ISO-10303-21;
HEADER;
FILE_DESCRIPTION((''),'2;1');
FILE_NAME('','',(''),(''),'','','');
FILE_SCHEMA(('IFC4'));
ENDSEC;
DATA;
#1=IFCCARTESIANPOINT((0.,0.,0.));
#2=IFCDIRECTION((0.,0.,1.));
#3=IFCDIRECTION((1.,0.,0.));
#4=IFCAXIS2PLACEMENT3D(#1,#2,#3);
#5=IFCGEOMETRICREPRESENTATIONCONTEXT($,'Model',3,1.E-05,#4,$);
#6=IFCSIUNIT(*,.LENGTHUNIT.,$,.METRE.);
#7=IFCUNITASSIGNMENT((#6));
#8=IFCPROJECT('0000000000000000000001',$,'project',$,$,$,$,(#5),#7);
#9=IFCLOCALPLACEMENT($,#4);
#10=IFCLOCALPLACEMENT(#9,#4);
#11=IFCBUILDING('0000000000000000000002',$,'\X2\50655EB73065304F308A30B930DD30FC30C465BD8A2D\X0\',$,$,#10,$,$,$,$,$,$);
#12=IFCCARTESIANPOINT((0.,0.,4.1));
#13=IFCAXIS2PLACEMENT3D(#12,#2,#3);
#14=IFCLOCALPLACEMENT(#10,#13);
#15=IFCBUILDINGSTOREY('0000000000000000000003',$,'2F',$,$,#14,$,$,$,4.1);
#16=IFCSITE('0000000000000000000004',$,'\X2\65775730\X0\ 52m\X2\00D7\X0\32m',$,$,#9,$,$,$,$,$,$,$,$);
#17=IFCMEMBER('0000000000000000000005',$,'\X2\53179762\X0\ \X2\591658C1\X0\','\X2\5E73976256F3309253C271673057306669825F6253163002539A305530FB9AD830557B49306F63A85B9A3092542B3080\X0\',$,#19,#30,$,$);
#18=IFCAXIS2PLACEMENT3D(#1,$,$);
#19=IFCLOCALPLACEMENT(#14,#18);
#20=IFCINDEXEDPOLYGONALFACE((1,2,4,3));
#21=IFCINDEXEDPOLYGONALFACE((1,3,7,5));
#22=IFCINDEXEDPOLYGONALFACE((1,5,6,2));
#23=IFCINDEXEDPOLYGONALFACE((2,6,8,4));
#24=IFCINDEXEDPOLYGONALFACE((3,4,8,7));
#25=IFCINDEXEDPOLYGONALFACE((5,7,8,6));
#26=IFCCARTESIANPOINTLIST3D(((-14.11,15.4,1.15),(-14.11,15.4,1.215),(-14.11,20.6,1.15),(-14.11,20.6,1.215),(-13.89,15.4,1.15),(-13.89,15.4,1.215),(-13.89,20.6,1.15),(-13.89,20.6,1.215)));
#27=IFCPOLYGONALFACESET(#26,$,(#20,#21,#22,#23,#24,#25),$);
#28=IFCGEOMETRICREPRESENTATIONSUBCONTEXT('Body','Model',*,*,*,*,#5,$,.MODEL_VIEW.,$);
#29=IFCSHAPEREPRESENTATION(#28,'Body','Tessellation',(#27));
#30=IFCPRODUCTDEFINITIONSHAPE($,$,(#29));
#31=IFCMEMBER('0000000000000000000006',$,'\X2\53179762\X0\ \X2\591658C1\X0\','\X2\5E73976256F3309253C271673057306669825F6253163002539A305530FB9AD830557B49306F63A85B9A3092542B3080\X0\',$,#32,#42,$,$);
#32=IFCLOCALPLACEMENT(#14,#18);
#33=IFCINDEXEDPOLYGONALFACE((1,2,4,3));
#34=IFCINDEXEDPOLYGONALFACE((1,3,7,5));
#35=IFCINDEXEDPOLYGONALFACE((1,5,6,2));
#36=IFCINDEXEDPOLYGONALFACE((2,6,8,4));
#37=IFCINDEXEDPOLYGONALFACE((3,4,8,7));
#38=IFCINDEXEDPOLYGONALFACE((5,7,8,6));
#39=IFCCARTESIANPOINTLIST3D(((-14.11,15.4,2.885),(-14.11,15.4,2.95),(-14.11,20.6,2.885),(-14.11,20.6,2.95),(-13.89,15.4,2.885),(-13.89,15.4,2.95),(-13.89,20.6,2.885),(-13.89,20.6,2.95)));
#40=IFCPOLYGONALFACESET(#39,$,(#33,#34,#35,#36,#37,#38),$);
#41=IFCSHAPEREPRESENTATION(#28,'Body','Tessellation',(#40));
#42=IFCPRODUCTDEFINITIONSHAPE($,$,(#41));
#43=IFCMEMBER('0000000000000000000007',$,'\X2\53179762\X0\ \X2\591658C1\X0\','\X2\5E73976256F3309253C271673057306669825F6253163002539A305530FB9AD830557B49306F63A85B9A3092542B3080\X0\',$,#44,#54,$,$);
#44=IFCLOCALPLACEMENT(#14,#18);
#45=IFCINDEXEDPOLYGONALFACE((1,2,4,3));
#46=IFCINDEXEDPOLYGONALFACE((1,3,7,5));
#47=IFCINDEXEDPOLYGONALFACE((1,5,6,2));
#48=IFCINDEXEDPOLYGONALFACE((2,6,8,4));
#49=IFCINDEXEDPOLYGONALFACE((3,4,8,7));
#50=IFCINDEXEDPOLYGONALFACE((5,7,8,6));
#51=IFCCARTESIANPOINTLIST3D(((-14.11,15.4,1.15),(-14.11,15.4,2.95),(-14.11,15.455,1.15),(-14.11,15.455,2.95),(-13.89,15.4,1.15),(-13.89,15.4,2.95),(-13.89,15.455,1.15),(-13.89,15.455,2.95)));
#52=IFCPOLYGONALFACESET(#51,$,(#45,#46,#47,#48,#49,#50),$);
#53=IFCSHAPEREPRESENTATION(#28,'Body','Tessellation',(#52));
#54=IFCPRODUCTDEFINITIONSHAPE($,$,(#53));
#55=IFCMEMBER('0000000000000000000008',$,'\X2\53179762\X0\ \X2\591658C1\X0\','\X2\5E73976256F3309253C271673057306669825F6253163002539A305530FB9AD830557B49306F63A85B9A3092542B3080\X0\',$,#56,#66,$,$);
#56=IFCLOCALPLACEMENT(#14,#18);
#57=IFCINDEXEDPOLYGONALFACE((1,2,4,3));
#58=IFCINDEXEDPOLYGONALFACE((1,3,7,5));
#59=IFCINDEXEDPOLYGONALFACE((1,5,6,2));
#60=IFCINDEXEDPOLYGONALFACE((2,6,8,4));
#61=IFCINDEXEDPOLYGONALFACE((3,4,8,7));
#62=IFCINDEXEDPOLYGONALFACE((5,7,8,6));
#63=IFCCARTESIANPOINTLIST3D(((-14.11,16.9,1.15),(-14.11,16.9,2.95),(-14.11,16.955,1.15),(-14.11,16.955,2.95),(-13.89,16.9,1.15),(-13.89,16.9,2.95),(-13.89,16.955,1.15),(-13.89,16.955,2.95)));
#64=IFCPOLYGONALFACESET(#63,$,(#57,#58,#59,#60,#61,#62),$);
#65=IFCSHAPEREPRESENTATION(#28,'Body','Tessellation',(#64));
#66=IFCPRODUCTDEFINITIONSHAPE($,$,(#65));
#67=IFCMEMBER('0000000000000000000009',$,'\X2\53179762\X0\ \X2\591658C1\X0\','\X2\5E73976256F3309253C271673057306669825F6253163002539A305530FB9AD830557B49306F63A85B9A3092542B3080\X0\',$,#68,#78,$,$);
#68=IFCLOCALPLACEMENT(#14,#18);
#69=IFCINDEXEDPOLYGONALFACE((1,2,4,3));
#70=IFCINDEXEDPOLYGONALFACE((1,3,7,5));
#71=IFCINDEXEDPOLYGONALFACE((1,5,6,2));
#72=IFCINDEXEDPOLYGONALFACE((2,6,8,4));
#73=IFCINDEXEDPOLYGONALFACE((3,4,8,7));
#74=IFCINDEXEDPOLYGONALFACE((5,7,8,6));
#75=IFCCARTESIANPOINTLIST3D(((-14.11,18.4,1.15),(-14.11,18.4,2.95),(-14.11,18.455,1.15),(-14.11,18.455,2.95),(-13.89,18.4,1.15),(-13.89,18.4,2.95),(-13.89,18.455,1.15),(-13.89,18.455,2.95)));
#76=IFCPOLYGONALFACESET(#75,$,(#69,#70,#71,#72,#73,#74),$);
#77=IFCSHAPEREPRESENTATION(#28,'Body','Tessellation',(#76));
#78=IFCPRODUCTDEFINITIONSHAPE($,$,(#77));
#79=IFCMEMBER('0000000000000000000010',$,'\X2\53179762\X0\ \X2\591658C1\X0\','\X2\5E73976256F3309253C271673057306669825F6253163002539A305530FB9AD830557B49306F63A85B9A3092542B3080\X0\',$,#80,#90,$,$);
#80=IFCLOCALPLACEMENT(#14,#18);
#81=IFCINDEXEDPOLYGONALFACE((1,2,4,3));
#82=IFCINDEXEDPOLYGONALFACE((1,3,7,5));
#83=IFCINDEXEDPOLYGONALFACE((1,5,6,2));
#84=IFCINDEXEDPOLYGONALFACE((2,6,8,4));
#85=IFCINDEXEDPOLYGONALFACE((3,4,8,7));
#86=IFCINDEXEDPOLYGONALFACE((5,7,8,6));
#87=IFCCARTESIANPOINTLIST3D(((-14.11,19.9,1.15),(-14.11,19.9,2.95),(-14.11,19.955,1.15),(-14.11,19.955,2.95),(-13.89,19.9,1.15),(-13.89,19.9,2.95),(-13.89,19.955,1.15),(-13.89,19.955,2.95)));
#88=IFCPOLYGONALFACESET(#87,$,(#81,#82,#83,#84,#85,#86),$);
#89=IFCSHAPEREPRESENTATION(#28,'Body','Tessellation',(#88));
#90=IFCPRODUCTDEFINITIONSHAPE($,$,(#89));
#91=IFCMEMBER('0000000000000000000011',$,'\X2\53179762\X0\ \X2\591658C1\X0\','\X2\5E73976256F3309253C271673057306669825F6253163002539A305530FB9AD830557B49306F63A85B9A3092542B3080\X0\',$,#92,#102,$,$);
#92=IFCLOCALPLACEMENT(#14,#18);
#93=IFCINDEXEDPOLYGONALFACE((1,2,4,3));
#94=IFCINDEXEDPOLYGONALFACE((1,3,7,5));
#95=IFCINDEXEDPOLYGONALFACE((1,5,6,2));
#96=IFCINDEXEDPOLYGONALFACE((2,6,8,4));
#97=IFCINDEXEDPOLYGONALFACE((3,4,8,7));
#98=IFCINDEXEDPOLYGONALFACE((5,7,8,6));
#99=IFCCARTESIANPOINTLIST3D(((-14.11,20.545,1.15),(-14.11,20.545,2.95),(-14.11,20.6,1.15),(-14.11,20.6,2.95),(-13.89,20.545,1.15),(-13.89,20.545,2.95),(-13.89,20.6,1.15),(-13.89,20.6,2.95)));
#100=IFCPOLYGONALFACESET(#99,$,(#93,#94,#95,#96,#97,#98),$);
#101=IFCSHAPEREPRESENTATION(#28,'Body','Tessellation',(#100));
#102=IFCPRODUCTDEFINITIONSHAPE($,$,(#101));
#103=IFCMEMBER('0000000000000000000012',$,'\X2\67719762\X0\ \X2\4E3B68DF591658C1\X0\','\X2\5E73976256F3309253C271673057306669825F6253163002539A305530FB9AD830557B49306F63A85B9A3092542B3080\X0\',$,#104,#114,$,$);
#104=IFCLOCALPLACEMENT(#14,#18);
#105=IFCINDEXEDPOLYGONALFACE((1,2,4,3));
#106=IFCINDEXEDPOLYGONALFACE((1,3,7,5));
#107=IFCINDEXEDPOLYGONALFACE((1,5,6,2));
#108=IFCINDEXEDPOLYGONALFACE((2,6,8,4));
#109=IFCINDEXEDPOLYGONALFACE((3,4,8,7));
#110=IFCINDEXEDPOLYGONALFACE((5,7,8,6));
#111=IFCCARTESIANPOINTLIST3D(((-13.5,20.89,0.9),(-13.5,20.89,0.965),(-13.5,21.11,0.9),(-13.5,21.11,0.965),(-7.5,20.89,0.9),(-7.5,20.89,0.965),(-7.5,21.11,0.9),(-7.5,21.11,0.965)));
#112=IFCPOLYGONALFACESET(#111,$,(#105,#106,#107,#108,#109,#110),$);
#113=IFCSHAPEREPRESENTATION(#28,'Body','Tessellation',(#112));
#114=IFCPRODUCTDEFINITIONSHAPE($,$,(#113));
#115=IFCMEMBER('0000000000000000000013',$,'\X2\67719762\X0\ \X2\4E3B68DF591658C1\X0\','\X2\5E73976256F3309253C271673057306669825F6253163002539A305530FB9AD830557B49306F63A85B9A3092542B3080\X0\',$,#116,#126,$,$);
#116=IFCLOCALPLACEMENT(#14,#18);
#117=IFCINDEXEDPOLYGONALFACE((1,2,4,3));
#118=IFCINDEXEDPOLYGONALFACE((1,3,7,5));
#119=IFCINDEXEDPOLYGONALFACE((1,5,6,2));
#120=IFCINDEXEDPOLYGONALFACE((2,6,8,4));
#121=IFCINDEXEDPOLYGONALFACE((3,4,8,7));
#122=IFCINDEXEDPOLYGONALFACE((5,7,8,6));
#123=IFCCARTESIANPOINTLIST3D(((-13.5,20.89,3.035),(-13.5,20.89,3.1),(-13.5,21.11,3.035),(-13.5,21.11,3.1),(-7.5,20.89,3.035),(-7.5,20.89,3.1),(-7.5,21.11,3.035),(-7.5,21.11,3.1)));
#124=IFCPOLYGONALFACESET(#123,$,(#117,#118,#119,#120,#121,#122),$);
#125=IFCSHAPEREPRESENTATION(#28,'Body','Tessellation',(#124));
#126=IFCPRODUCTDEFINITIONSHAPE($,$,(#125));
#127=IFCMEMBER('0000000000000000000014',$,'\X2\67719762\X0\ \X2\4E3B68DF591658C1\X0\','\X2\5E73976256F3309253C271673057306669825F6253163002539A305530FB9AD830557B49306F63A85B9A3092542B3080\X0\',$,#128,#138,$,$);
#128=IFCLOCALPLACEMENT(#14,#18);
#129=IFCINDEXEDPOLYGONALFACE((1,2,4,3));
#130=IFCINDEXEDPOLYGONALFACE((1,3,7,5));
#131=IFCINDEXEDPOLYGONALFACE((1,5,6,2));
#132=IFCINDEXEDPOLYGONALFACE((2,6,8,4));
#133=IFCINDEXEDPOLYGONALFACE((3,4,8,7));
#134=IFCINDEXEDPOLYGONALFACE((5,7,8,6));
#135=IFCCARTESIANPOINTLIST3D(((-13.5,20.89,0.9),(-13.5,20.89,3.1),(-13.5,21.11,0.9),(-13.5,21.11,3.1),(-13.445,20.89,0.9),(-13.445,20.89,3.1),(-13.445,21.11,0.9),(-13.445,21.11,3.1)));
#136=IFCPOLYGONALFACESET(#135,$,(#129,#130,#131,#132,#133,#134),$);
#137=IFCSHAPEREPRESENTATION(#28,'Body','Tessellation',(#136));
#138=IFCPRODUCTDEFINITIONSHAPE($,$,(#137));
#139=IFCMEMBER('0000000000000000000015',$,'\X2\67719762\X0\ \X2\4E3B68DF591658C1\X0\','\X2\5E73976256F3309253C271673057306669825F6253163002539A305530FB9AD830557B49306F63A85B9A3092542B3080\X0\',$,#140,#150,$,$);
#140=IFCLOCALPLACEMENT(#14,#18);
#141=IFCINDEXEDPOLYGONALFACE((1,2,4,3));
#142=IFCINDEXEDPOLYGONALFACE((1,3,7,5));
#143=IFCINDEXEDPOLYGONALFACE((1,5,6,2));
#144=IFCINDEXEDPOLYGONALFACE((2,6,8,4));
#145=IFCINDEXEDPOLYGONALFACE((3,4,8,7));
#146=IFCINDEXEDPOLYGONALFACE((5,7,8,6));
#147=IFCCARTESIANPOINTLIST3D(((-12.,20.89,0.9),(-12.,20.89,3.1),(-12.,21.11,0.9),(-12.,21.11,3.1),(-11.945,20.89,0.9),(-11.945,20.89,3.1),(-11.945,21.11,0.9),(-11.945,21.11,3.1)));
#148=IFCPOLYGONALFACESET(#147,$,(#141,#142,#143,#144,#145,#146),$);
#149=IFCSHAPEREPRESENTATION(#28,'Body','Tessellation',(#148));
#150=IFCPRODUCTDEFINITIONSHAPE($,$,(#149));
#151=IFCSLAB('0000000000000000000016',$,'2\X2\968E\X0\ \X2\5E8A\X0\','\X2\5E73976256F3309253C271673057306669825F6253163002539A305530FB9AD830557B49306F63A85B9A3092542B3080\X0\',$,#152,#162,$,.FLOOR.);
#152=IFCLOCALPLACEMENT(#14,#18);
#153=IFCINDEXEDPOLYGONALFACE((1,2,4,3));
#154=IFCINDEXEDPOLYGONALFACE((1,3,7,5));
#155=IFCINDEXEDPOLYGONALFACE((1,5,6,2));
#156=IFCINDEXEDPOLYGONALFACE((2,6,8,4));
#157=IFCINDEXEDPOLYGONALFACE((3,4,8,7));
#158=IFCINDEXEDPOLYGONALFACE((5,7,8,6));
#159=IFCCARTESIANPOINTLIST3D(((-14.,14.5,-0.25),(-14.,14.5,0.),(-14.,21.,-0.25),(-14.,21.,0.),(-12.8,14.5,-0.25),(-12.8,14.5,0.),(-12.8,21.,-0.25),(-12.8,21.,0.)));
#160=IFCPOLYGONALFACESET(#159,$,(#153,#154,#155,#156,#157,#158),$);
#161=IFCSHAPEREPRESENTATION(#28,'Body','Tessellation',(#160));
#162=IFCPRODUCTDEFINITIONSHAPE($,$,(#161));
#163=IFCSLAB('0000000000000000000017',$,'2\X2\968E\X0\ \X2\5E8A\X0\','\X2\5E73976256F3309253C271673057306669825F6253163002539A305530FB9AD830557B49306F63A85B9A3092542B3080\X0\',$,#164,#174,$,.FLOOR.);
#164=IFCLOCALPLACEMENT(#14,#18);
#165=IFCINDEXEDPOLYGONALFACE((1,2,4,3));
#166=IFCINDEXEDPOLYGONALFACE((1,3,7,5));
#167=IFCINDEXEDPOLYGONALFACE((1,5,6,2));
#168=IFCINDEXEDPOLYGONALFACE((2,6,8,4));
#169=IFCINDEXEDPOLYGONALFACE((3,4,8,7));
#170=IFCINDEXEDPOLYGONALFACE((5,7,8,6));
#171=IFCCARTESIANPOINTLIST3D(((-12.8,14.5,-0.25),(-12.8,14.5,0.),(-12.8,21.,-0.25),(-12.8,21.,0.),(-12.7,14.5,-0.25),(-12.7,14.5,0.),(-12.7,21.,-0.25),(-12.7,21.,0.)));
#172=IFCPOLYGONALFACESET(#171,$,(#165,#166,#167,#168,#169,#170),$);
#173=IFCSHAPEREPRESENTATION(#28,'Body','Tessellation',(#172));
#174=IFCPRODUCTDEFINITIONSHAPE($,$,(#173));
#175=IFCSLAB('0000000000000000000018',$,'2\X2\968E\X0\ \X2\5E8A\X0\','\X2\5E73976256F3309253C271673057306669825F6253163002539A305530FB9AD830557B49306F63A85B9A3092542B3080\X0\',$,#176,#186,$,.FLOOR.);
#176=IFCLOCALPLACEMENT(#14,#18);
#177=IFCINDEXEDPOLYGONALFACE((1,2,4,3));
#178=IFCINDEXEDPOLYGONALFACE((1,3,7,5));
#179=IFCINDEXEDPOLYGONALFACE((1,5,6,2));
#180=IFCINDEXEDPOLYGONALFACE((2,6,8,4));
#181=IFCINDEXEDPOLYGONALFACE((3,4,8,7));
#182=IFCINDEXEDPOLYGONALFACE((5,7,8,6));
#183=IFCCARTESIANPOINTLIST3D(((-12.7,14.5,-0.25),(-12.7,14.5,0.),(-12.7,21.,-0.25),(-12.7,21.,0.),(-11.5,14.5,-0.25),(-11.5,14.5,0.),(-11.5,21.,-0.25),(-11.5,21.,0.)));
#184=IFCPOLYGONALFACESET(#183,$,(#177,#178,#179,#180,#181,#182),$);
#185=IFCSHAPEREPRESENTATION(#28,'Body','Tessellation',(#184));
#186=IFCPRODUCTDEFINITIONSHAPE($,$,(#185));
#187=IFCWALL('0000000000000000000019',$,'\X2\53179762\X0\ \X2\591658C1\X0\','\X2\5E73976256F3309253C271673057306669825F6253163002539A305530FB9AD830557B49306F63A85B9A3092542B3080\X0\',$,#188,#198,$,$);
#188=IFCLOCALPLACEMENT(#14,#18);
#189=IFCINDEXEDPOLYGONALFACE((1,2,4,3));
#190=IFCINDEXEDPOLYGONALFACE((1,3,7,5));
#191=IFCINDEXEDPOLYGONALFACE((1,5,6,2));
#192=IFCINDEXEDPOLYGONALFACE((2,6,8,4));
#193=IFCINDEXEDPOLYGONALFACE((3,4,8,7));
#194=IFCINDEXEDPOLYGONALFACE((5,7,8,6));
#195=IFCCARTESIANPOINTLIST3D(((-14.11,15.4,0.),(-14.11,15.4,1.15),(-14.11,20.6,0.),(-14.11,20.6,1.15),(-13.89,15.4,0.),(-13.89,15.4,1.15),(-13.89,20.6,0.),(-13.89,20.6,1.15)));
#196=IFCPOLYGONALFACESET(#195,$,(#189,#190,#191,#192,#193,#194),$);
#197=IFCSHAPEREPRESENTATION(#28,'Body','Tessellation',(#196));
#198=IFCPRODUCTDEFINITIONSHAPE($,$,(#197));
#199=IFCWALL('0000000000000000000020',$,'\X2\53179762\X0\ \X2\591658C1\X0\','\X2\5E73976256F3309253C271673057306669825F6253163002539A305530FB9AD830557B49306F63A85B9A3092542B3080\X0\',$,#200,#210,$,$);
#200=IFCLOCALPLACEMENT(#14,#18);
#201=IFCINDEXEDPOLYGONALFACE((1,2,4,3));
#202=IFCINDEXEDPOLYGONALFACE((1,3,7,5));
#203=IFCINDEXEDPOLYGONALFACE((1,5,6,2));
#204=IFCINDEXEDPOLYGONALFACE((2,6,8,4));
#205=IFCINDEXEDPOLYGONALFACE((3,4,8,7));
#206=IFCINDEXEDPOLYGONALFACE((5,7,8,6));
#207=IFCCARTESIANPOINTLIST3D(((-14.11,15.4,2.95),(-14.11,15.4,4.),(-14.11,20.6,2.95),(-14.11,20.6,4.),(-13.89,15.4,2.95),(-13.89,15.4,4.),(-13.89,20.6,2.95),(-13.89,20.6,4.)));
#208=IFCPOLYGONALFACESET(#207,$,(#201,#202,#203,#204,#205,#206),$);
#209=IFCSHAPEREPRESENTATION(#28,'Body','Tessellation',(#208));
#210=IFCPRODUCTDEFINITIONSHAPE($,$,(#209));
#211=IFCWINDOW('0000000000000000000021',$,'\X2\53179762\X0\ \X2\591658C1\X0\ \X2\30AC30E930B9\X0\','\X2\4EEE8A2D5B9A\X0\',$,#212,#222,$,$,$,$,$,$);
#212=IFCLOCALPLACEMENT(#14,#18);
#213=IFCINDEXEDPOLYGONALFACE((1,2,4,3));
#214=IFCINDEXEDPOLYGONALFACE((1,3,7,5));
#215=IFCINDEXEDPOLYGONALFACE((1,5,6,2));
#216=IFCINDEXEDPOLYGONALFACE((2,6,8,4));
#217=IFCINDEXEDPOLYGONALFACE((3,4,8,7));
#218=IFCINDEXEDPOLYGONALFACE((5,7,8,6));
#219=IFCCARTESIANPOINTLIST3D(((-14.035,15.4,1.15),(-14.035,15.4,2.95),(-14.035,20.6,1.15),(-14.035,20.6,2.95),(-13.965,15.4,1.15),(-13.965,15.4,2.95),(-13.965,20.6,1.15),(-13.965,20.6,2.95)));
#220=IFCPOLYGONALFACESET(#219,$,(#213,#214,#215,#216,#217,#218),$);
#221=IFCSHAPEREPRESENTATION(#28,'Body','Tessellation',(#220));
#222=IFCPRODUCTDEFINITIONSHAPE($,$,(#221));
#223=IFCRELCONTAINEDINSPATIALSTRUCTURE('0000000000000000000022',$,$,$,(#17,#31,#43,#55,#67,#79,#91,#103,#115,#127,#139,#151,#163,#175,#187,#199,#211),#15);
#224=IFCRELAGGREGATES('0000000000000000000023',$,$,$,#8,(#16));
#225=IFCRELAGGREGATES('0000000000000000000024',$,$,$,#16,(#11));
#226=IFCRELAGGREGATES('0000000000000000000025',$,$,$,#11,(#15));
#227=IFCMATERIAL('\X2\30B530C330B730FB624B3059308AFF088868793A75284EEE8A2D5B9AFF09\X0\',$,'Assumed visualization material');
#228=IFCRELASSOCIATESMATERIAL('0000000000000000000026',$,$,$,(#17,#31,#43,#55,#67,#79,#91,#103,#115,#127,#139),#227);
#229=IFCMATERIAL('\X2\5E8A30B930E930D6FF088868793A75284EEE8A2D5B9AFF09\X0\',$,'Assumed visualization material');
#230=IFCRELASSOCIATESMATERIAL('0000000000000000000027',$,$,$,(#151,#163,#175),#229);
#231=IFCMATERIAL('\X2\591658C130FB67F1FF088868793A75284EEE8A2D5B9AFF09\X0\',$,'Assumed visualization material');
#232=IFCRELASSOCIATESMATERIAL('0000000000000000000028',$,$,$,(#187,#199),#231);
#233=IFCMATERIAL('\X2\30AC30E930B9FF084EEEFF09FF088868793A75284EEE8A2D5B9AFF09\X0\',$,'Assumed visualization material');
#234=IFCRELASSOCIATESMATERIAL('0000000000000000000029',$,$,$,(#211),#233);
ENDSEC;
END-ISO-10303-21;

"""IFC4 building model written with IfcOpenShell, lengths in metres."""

from ifc_helpers import new_model, si_unit, frame, origin_with_axes, place, context, subcontext, project, spatial, rectangle, extrude, material, element, save


model = new_model("IFC4")

# Units and contexts
model_context = context("Model", 3, precision=1e-05, world=origin_with_axes())
body_context = subcontext(model_context, "Body", "Model", "MODEL_VIEW")
ifc_project = project(units=[si_unit("LENGTHUNIT", "METRE")], contexts=[model_context])

# Site, building, storey
site_placement = place(None, origin_with_axes())
site = spatial("IfcSite", under=ifc_project, at=site_placement, Name="敷地 52m×32m")
building_placement = place(site_placement, origin_with_axes())
building = spatial("IfcBuilding", under=site, at=building_placement, Name="健康づくりスポーツ施設")
storey_placement = place(building_placement, frame((0.0, 0.0, 4.1), z_axis=(0.0, 0.0, 1.0), x_axis=(1.0, 0.0, 0.0)))
storey = spatial("IfcBuildingStorey", under=building, at=storey_placement, Name="2F", Elevation=4.1)

# Members
ifc_material_1 = material(Name="サッシ・手すり（表示用仮設定）", Category="Assumed visualization material")
for number, where, z_axis, x_axis, name in (
    (1, (-14.0, 18.0, 1.15), (0.0, 0.0, 1.0), (1.0, 0.0, 0.0), "北面 外壁"),
    (2, (-14.0, 18.0, 2.885), (0.0, 0.0, 1.0), (1.0, 0.0, 0.0), "北面 外壁"),
):
    element("IfcMember", number, at=place(storey_placement, frame(where, z_axis=z_axis, x_axis=x_axis)), inside=storey, material=ifc_material_1, Name=name, Description="平面図を参照して概形化。厚さ・高さ等は推定を含む", context=body_context, shape_type="SweptSolid", body=[
        extrude(rectangle(XDim=0.22, YDim=5.2), origin_with_axes(), (0.0, 0.0, 1.0), 0.065),
    ])
for number, where, z_axis, x_axis, name in (
    (3, (-14.0, 15.4275, 1.15), (0.0, 0.0, 1.0), (1.0, 0.0, 0.0), "北面 外壁"),
    (4, (-14.0, 16.9275, 1.15), (0.0, 0.0, 1.0), (1.0, 0.0, 0.0), "北面 外壁"),
    (5, (-14.0, 18.4275, 1.15), (0.0, 0.0, 1.0), (1.0, 0.0, 0.0), "北面 外壁"),
    (6, (-14.0, 19.9275, 1.15), (0.0, 0.0, 1.0), (1.0, 0.0, 0.0), "北面 外壁"),
    (7, (-14.0, 20.5725, 1.15), (0.0, 0.0, 1.0), (1.0, 0.0, 0.0), "北面 外壁"),
):
    element("IfcMember", number, at=place(storey_placement, frame(where, z_axis=z_axis, x_axis=x_axis)), inside=storey, material=ifc_material_1, Name=name, Description="平面図を参照して概形化。厚さ・高さ等は推定を含む", context=body_context, shape_type="SweptSolid", body=[
        extrude(rectangle(XDim=0.22, YDim=0.055), origin_with_axes(), (0.0, 0.0, 1.0), 1.8),
    ])
for number, where, z_axis, x_axis, name in (
    (8, (-10.5, 21.0, 0.9), (0.0, 0.0, 1.0), (1.0, 0.0, 0.0), "東面 主棟外壁"),
    (9, (-10.5, 21.0, 3.035), (0.0, 0.0, 1.0), (1.0, 0.0, 0.0), "東面 主棟外壁"),
):
    element("IfcMember", number, at=place(storey_placement, frame(where, z_axis=z_axis, x_axis=x_axis)), inside=storey, material=ifc_material_1, Name=name, Description="平面図を参照して概形化。厚さ・高さ等は推定を含む", context=body_context, shape_type="SweptSolid", body=[
        extrude(rectangle(XDim=6.0, YDim=0.22), origin_with_axes(), (0.0, 0.0, 1.0), 0.065),
    ])
member_1_placement = place(storey_placement, frame((-13.4725, 21.0, 0.9), z_axis=(0.0, 0.0, 1.0), x_axis=(1.0, 0.0, 0.0)))
element("IfcMember", 10, at=member_1_placement, inside=storey, material=ifc_material_1, Name="東面 主棟外壁", Description="平面図を参照して概形化。厚さ・高さ等は推定を含む", context=body_context, shape_type="SweptSolid", body=[
    extrude(rectangle(XDim=0.055, YDim=0.22), origin_with_axes(), (0.0, 0.0, 1.0), 2.2),
])
member_2_placement = place(storey_placement, frame((-11.9725, 21.0, 0.9), z_axis=(0.0, 0.0, 1.0), x_axis=(1.0, 0.0, 0.0)))
element("IfcMember", 11, at=member_2_placement, inside=storey, material=ifc_material_1, Name="東面 主棟外壁", Description="平面図を参照して概形化。厚さ・高さ等は推定を含む", context=body_context, shape_type="SweptSolid", body=[
    extrude(rectangle(XDim=0.055, YDim=0.22), origin_with_axes(), (0.0, 0.0, 1.0), 2.2),
])

# Slabs
ifc_material_2 = material(Name="床スラブ（表示用仮設定）", Category="Assumed visualization material")
slab_1_placement = place(storey_placement, frame((-13.4, 17.75, -0.25), z_axis=(0.0, 0.0, 1.0), x_axis=(1.0, 0.0, 0.0)))
element("IfcSlab", 12, at=slab_1_placement, inside=storey, material=ifc_material_2, Name="2階 床", Description="平面図を参照して概形化。厚さ・高さ等は推定を含む", PredefinedType="FLOOR", context=body_context, shape_type="SweptSolid", body=[
    extrude(rectangle(XDim=1.2, YDim=6.5), origin_with_axes(), (0.0, 0.0, 1.0), 0.25),
])
slab_2_placement = place(storey_placement, frame((-12.75, 17.75, -0.25), z_axis=(0.0, 0.0, 1.0), x_axis=(1.0, 0.0, 0.0)))
element("IfcSlab", 13, at=slab_2_placement, inside=storey, material=ifc_material_2, Name="2階 床", Description="平面図を参照して概形化。厚さ・高さ等は推定を含む", PredefinedType="FLOOR", context=body_context, shape_type="SweptSolid", body=[
    extrude(rectangle(XDim=0.1, YDim=6.5), origin_with_axes(), (0.0, 0.0, 1.0), 0.25),
])
slab_3_placement = place(storey_placement, frame((-12.1, 17.75, -0.25), z_axis=(0.0, 0.0, 1.0), x_axis=(1.0, 0.0, 0.0)))
element("IfcSlab", 14, at=slab_3_placement, inside=storey, material=ifc_material_2, Name="2階 床", Description="平面図を参照して概形化。厚さ・高さ等は推定を含む", PredefinedType="FLOOR", context=body_context, shape_type="SweptSolid", body=[
    extrude(rectangle(XDim=1.2, YDim=6.5), origin_with_axes(), (0.0, 0.0, 1.0), 0.25),
])

# Walls
ifc_material_3 = material(Name="外壁・柱（表示用仮設定）", Category="Assumed visualization material")
wall_1_placement = place(storey_placement, frame((-14.0, 18.0, 0.0), z_axis=(0.0, 0.0, 1.0), x_axis=(1.0, 0.0, 0.0)))
element("IfcWall", 15, at=wall_1_placement, inside=storey, material=ifc_material_3, Name="北面 外壁", Description="平面図を参照して概形化。厚さ・高さ等は推定を含む", context=body_context, shape_type="SweptSolid", body=[
    extrude(rectangle(XDim=0.22, YDim=5.2), origin_with_axes(), (0.0, 0.0, 1.0), 1.15),
])
wall_2_placement = place(storey_placement, frame((-14.0, 18.0, 2.95), z_axis=(0.0, 0.0, 1.0), x_axis=(1.0, 0.0, 0.0)))
element("IfcWall", 16, at=wall_2_placement, inside=storey, material=ifc_material_3, Name="北面 外壁", Description="平面図を参照して概形化。厚さ・高さ等は推定を含む", context=body_context, shape_type="SweptSolid", body=[
    extrude(rectangle(XDim=0.22, YDim=5.2), origin_with_axes(), (0.0, 0.0, 1.0), 1.05),
])

# Window
ifc_material_4 = material(Name="ガラス（仮）（表示用仮設定）", Category="Assumed visualization material")
window_1_placement = place(storey_placement, frame((-14.0, 18.0, 1.15), z_axis=(0.0, 0.0, 1.0), x_axis=(1.0, 0.0, 0.0)))
element("IfcWindow", 17, at=window_1_placement, inside=storey, material=ifc_material_4, Name="北面 外壁 ガラス", Description="仮設定", context=body_context, shape_type="SweptSolid", body=[
    extrude(rectangle(XDim=0.07, YDim=5.2), origin_with_axes(), (0.0, 0.0, 1.0), 1.8),
])

save(model, "model.ifc")
